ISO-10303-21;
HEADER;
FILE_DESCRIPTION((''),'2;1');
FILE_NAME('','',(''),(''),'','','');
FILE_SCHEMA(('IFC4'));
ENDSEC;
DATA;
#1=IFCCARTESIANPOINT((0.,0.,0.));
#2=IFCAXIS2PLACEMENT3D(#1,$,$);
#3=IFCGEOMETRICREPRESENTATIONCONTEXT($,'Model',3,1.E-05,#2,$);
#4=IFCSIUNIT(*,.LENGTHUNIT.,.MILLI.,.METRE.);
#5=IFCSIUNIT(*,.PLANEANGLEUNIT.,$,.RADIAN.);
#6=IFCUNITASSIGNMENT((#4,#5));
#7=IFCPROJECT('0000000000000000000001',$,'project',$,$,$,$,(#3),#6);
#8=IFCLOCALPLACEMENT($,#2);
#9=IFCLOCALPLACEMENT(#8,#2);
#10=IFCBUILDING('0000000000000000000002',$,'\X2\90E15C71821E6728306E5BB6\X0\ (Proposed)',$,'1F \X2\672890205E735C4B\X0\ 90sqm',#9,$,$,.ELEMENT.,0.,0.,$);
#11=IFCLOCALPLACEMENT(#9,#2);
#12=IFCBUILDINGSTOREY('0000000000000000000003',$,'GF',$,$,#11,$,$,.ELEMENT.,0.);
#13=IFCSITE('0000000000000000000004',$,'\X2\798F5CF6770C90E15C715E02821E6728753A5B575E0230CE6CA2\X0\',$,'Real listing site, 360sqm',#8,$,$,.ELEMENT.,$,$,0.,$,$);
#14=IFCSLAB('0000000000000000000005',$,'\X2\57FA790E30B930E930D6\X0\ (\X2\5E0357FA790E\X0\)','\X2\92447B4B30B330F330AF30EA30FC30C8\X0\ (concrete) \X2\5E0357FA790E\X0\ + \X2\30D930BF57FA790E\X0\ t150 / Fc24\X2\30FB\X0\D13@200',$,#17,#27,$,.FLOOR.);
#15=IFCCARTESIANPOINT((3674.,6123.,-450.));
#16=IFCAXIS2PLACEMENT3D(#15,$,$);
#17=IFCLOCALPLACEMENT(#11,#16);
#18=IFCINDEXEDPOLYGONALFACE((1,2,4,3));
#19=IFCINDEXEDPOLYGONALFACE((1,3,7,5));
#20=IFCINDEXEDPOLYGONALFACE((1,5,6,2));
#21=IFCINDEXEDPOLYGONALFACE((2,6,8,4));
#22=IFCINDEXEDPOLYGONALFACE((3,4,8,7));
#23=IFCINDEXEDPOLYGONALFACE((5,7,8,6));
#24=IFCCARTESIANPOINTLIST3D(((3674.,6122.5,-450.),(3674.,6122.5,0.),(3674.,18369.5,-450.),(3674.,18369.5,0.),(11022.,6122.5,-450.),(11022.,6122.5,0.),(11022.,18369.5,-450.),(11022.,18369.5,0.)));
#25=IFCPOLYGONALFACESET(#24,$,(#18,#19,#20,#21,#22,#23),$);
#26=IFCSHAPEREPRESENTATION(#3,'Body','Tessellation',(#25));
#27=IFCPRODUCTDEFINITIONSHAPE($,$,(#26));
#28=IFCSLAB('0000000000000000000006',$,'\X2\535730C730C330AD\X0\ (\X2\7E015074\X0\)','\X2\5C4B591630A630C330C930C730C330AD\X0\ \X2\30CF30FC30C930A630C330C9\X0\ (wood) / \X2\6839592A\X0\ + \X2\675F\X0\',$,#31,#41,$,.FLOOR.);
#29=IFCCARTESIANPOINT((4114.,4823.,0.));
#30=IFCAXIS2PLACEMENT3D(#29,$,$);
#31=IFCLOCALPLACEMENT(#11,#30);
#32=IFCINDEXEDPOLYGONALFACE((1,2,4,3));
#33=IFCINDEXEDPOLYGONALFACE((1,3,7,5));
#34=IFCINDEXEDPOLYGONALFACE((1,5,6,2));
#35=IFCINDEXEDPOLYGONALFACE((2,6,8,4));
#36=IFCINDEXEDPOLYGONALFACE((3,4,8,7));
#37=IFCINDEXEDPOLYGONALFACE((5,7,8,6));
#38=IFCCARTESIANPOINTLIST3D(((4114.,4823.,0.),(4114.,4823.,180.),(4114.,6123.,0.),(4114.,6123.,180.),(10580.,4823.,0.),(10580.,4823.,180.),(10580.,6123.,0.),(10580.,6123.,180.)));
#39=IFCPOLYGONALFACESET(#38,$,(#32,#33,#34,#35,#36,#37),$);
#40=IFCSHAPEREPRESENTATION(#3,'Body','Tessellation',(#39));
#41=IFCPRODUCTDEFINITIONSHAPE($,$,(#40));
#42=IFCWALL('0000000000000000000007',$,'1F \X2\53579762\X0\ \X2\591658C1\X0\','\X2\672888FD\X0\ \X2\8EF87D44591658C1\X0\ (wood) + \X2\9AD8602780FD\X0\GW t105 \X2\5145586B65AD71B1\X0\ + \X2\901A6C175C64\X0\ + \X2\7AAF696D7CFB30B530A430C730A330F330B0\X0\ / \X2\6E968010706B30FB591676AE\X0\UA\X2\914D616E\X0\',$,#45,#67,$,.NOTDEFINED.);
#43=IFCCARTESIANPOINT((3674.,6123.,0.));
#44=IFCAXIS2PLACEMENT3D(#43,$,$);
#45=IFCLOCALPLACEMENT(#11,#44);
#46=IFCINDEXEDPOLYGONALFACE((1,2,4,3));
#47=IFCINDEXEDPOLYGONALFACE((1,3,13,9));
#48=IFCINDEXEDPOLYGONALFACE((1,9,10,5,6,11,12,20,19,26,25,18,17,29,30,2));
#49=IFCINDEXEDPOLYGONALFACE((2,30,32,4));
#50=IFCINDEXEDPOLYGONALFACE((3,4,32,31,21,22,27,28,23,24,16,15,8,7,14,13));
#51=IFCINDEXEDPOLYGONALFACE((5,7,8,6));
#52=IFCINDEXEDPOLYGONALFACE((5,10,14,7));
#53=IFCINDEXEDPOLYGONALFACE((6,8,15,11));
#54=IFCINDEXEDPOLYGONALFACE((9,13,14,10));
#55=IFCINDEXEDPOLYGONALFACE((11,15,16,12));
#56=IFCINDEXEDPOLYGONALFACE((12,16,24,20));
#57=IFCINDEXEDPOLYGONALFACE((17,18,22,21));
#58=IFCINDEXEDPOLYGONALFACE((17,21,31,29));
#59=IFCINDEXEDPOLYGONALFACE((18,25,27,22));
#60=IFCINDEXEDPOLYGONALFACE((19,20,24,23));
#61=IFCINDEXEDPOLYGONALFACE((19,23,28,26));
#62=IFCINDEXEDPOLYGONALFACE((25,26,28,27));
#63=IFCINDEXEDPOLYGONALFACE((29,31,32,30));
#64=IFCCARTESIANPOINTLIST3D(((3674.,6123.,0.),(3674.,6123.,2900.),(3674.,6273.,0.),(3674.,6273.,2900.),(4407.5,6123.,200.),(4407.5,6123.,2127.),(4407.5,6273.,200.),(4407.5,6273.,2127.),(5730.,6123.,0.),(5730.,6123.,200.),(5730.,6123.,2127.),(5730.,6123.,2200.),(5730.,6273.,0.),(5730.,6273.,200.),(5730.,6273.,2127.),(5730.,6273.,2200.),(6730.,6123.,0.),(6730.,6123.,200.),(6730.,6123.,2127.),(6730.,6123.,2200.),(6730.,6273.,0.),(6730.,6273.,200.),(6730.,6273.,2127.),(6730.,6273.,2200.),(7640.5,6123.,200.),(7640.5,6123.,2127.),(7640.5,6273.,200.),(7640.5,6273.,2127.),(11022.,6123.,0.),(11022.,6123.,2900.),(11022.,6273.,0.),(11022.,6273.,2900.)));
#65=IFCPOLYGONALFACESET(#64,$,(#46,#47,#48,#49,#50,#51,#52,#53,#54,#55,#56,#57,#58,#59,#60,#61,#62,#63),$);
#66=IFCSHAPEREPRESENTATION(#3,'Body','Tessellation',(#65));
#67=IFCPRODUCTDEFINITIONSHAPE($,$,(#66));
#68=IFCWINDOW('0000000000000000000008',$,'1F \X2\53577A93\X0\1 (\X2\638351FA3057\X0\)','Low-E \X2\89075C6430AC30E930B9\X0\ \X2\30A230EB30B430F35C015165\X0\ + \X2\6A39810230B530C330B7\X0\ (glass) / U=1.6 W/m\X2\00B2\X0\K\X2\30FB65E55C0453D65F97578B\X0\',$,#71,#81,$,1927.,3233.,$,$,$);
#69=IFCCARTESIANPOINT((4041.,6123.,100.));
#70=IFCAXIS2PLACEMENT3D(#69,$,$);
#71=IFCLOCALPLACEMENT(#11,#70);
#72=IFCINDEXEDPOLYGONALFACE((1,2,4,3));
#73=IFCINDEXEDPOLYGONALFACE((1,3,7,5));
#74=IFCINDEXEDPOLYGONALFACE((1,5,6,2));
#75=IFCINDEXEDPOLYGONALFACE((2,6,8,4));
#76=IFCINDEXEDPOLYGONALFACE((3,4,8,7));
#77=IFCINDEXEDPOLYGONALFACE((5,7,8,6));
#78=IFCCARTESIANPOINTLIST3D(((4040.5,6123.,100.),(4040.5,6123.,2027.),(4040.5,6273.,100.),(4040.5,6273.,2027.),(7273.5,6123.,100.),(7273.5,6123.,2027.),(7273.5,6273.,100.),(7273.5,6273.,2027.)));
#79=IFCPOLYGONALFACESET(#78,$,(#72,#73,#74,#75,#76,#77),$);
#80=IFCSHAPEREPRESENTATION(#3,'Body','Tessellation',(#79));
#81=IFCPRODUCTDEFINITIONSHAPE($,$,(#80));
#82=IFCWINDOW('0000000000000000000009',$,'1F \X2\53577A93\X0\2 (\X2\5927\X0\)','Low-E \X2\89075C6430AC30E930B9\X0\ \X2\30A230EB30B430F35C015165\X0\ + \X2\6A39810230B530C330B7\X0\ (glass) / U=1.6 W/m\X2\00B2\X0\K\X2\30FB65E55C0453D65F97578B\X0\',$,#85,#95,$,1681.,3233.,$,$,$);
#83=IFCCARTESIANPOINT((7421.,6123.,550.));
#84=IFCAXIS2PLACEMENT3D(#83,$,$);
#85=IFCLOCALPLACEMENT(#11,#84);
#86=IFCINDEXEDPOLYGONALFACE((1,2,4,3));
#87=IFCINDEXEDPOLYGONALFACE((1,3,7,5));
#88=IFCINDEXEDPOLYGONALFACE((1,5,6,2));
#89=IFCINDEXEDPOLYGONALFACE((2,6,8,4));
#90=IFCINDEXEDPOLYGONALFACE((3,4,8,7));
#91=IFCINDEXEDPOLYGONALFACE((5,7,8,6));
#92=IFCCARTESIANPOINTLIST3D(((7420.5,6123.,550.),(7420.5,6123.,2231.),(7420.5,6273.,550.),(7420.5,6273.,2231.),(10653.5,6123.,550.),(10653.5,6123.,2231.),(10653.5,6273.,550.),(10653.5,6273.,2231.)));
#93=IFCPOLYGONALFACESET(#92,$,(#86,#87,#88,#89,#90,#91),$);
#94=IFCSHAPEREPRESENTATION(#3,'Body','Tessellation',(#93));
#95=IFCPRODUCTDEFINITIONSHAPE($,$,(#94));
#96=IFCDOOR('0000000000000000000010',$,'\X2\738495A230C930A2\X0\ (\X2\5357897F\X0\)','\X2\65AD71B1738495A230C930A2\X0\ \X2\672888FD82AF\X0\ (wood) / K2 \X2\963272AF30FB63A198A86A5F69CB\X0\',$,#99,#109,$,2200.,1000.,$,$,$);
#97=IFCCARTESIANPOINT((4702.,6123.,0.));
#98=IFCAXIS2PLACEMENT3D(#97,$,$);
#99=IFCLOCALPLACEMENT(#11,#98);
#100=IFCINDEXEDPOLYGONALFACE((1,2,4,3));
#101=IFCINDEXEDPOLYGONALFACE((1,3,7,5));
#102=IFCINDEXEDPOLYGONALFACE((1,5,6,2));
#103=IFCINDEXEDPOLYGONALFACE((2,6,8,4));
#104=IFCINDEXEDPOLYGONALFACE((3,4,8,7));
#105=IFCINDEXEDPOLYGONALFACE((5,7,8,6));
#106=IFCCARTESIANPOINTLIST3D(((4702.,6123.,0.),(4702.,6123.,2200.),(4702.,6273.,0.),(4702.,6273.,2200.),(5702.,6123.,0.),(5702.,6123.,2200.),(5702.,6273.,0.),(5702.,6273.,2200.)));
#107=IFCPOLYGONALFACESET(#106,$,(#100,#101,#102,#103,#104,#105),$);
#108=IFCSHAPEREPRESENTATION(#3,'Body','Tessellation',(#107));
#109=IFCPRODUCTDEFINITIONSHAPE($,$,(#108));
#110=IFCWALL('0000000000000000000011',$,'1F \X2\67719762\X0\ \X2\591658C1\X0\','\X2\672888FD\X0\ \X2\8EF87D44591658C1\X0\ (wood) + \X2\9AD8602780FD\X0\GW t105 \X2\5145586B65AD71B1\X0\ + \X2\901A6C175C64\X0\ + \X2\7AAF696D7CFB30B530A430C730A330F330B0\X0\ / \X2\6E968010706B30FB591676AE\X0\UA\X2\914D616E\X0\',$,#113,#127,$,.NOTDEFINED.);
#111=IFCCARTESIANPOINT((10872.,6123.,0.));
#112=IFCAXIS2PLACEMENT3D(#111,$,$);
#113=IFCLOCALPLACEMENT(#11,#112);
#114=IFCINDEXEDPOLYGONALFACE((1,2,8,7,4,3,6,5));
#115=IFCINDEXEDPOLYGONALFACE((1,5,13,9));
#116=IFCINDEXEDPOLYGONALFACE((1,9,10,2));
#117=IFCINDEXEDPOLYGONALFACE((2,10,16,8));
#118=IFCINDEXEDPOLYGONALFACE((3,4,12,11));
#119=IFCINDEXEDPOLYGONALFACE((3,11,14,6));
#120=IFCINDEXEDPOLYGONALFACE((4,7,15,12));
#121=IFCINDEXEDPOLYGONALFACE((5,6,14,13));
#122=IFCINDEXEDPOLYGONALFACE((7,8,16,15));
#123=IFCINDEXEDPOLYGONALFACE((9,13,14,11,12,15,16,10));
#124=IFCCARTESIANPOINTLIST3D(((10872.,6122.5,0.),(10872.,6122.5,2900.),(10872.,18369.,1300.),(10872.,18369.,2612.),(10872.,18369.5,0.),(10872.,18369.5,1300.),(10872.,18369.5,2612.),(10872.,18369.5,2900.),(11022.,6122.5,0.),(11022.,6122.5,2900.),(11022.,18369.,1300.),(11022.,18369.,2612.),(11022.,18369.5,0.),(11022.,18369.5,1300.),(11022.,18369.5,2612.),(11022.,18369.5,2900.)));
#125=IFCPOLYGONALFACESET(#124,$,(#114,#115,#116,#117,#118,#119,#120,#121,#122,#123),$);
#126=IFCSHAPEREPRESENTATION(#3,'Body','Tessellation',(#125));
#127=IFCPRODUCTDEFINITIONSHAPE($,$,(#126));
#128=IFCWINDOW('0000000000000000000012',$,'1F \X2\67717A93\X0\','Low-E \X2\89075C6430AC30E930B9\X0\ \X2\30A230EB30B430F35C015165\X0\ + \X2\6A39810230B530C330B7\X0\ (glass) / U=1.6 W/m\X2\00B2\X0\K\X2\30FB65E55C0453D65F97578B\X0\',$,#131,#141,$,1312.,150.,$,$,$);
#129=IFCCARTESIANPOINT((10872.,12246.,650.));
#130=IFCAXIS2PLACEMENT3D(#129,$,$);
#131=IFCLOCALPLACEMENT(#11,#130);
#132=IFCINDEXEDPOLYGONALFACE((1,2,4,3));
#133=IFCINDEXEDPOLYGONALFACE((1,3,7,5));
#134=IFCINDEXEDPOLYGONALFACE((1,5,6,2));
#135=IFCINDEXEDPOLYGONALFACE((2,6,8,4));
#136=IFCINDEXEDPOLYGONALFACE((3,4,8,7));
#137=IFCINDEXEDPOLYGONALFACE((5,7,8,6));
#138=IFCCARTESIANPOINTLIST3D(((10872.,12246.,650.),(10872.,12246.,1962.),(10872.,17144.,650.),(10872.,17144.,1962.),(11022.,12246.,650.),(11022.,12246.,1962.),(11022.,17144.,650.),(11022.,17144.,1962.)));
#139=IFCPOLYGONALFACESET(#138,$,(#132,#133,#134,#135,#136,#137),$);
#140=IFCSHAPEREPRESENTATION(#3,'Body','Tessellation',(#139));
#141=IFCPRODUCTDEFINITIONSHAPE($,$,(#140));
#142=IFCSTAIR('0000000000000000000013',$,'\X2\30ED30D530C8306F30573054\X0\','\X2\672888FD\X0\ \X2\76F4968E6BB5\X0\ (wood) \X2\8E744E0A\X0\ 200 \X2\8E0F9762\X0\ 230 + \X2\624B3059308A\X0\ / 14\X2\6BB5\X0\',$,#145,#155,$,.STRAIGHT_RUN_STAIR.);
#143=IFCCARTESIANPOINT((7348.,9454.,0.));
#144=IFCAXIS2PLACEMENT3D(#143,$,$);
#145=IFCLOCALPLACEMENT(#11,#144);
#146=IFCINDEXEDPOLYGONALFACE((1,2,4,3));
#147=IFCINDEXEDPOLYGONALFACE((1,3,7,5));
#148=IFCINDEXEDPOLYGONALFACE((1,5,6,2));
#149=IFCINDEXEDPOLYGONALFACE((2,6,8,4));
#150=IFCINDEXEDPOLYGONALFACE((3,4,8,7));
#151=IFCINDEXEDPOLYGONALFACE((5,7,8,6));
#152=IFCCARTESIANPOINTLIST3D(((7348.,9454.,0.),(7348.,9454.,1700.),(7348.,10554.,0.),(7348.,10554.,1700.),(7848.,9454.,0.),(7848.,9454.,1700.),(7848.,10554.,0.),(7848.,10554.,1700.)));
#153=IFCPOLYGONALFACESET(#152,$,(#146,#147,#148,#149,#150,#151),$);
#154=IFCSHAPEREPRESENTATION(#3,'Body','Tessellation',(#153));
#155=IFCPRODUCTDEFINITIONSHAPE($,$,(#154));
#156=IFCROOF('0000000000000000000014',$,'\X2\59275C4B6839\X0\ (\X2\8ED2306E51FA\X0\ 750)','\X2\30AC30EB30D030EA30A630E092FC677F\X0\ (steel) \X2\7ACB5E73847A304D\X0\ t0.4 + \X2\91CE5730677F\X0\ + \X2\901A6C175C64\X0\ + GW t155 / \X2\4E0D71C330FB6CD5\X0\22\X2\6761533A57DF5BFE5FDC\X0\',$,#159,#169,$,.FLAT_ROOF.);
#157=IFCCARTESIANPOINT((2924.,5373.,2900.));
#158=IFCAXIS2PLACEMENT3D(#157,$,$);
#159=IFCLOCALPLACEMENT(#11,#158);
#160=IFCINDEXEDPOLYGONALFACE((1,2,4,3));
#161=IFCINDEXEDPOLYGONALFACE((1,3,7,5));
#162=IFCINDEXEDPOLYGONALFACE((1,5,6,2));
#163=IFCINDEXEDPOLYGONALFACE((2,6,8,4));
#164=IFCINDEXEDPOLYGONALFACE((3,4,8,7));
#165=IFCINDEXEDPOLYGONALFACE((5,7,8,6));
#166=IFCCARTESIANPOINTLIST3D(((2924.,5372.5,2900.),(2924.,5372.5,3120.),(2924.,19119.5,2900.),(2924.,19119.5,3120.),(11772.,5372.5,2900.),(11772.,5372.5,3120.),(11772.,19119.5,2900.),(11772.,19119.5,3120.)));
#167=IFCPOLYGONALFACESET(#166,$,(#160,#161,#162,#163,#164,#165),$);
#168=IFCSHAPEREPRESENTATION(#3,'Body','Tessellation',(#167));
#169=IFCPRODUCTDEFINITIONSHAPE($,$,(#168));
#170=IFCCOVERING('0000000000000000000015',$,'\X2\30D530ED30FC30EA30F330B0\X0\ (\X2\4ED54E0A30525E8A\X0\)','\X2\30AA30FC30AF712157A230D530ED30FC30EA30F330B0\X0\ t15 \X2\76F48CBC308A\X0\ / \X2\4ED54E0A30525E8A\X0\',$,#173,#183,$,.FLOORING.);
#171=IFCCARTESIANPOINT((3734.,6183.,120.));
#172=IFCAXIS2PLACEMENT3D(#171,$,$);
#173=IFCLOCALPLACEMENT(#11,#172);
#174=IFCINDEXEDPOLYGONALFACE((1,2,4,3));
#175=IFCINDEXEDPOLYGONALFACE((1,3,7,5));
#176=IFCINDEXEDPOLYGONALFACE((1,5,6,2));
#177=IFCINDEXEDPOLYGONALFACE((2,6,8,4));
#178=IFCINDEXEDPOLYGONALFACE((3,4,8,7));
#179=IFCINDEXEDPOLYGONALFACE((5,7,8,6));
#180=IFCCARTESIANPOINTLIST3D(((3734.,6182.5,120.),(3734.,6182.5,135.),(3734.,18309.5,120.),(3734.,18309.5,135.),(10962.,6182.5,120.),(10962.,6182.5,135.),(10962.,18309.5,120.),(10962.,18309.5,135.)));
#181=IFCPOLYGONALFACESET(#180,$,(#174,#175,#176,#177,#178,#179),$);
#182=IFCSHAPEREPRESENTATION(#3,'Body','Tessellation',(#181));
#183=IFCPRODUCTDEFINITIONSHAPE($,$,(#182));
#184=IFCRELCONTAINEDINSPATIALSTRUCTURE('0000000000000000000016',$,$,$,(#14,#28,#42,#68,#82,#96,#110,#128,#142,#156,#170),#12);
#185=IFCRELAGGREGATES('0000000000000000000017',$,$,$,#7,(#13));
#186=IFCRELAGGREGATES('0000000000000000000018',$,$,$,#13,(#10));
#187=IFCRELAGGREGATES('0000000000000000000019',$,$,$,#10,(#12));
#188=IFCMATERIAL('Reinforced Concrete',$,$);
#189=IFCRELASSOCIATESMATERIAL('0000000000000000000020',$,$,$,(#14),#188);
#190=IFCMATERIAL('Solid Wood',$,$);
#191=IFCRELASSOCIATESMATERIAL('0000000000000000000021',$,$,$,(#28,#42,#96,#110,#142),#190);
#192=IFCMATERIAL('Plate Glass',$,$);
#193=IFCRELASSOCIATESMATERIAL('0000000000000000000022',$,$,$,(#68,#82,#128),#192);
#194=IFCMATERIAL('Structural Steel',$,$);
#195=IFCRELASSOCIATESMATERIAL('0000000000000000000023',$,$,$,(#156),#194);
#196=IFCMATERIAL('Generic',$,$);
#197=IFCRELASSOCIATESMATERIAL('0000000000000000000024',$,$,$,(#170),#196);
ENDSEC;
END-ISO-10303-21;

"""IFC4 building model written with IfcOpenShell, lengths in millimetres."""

from ifc_helpers import new_model, si_unit, frame, frame_2d, origin, place, context, project, spatial, rectangle, extrude, material, element, fill, save


model = new_model("IFC4")

# Units and contexts
model_context = context("Model", 3, precision=1e-05, world=origin())
ifc_project = project(units=[si_unit("LENGTHUNIT", "METRE", prefix="MILLI"), si_unit("PLANEANGLEUNIT", "RADIAN")], contexts=[model_context])

# Site, building, storey
site_placement = place(None, origin())
site = spatial("IfcSite", under=ifc_project, at=site_placement, Name="福島県郡山市舞木町字市ノ沢", ObjectType="Real listing site, 360sqm", CompositionType="ELEMENT", RefElevation=0.0)
building_placement = place(site_placement, origin())
building = spatial("IfcBuilding", under=site, at=building_placement, Name="郡山舞木の家 (Proposed)", ObjectType="1F 木造平屋 90sqm", CompositionType="ELEMENT", ElevationOfRefHeight=0.0, ElevationOfTerrain=0.0)
storey_placement = place(building_placement, origin())
storey = spatial("IfcBuildingStorey", under=building, at=storey_placement, Name="GF", CompositionType="ELEMENT", Elevation=0.0)

# Slabs
ifc_material_1 = material(Name="Reinforced Concrete")
slab_1_placement = place(storey_placement, frame((3674.0, 6123.0, -450.0)))
element("IfcSlab", 1, at=slab_1_placement, inside=storey, material=ifc_material_1, Name="基礎スラブ (布基礎)", Description="鉄筋コンクリート (concrete) 布基礎 + ベタ基礎 t150 / Fc24・D13@200", PredefinedType="FLOOR", context=model_context, shape_type="SweptSolid", body=[
    extrude(rectangle(XDim=7348.0, YDim=12247.0, at=frame_2d((3674.0, 6123.0))), frame((3674.0, 6123.0, -450.0)), (0.0, 0.0, 1.0), 450.0),
])
ifc_material_2 = material(Name="Solid Wood")
slab_2_placement = place(storey_placement, frame((4114.0, 4823.0, 0.0)))
element("IfcSlab", 2, at=slab_2_placement, inside=storey, material=ifc_material_2, Name="南デッキ (縁側)", Description="屋外ウッドデッキ ハードウッド (wood) / 根太 + 束", PredefinedType="FLOOR", context=model_context, shape_type="SweptSolid", body=[
    extrude(rectangle(XDim=6466.0, YDim=1300.0, at=frame_2d((3233.0, 650.0))), frame((4114.0, 4823.0, 0.0)), (0.0, 0.0, 1.0), 180.0),
])

# Wall, openings, windows, door
wall_1_placement = place(storey_placement, frame((3674.0, 6123.0, 0.0)))
wall_1 = element("IfcWall", 3, at=wall_1_placement, inside=storey, material=ifc_material_2, Name="1F 南面 外壁", Description="木製 軸組外壁 (wood) + 高性能GW t105 充填断熱 + 通気層 + 窯業系サイディング / 準耐火・外皮UA配慮", PredefinedType="NOTDEFINED", context=model_context, shape_type="SweptSolid", body=[
    extrude(rectangle(XDim=7348.0, YDim=150.0, at=frame_2d((3674.0, 75.0))), frame((3674.0, 6123.0, 0.0)), (0.0, 0.0, 1.0), 2900.0),
])
opening_1_placement = place(storey_placement, frame((4041.0, 6123.0, 100.0)))
opening_1 = element("IfcOpeningElement", 4, at=opening_1_placement, cuts=wall_1, PredefinedType="NOTDEFINED", context=model_context, shape_type="SweptSolid", body=[
    extrude(rectangle(XDim=3233.0, YDim=150.0, at=frame_2d((1616.0, 75.0))), frame((4041.0, 6123.0, 100.0)), (0.0, 0.0, 1.0), 1927.0),
])
opening_2_placement = place(storey_placement, frame((7421.0, 6123.0, 550.0)))
opening_2 = element("IfcOpeningElement", 5, at=opening_2_placement, cuts=wall_1, PredefinedType="NOTDEFINED", context=model_context, shape_type="SweptSolid", body=[
    extrude(rectangle(XDim=3233.0, YDim=150.0, at=frame_2d((1616.0, 75.0))), frame((7421.0, 6123.0, 550.0)), (0.0, 0.0, 1.0), 1681.0),
])
opening_3_placement = place(storey_placement, frame((4702.0, 6123.0, 0.0)))
opening_3 = element("IfcOpeningElement", 6, at=opening_3_placement, cuts=wall_1, PredefinedType="NOTDEFINED", context=model_context, shape_type="SweptSolid", body=[
    extrude(rectangle(XDim=1000.0, YDim=150.0, at=frame_2d((500.0, 75.0))), frame((4702.0, 6123.0, 0.0)), (0.0, 0.0, 1.0), 2200.0),
])
ifc_material_3 = material(Name="Plate Glass")
window_1_placement = place(storey_placement, frame((4041.0, 6123.0, 100.0)))
window_1 = element("IfcWindow", 7, at=window_1_placement, inside=storey, material=ifc_material_3, Name="1F 南窓1 (掃出し)", Description="Low-E 複層ガラス アルゴン封入 + 樹脂サッシ (glass) / U=1.6 W/m²K・日射取得型", OverallHeight=1927.0, OverallWidth=3233.0, context=model_context, shape_type="SweptSolid", body=[
    extrude(rectangle(XDim=3233.0, YDim=150.0, at=frame_2d((1616.0, 75.0))), frame((4041.0, 6123.0, 100.0)), (0.0, 0.0, 1.0), 1927.0),
])
fill(opening_1, window_1)
window_2_placement = place(storey_placement, frame((7421.0, 6123.0, 550.0)))
window_2 = element("IfcWindow", 8, at=window_2_placement, inside=storey, material=ifc_material_3, Name="1F 南窓2 (大)", Description="Low-E 複層ガラス アルゴン封入 + 樹脂サッシ (glass) / U=1.6 W/m²K・日射取得型", OverallHeight=1681.0, OverallWidth=3233.0, context=model_context, shape_type="SweptSolid", body=[
    extrude(rectangle(XDim=3233.0, YDim=150.0, at=frame_2d((1616.0, 75.0))), frame((7421.0, 6123.0, 550.0)), (0.0, 0.0, 1.0), 1681.0),
])
fill(opening_2, window_2)
door_placement = place(storey_placement, frame((4702.0, 6123.0, 0.0)))
door = element("IfcDoor", 9, at=door_placement, inside=storey, material=ifc_material_2, Name="玄関ドア (南西)", Description="断熱玄関ドア 木製芯 (wood) / K2 防犯・採風機構", OverallHeight=2200.0, OverallWidth=1000.0, context=model_context, shape_type="SweptSolid", body=[
    extrude(rectangle(XDim=1000.0, YDim=150.0, at=frame_2d((500.0, 75.0))), frame((4702.0, 6123.0, 0.0)), (0.0, 0.0, 1.0), 2200.0),
])
fill(opening_3, door)

# Wall, opening, window
wall_2_placement = place(storey_placement, frame((10872.0, 6123.0, 0.0)))
wall_2 = element("IfcWall", 10, at=wall_2_placement, inside=storey, material=ifc_material_2, Name="1F 東面 外壁", Description="木製 軸組外壁 (wood) + 高性能GW t105 充填断熱 + 通気層 + 窯業系サイディング / 準耐火・外皮UA配慮", PredefinedType="NOTDEFINED", context=model_context, shape_type="SweptSolid", body=[
    extrude(rectangle(XDim=150.0, YDim=12247.0, at=frame_2d((75.0, 6123.0))), frame((10872.0, 6123.0, 0.0)), (0.0, 0.0, 1.0), 2900.0),
])
opening_4_placement = place(storey_placement, frame((10872.0, 12246.0, 650.0)))
opening_4 = element("IfcOpeningElement", 11, at=opening_4_placement, cuts=wall_2, PredefinedType="NOTDEFINED", context=model_context, shape_type="SweptSolid", body=[
    extrude(rectangle(XDim=150.0, YDim=4898.0, at=frame_2d((75.0, 2449.0))), frame((10872.0, 12246.0, 650.0)), (0.0, 0.0, 1.0), 1312.0),
])
window_3_placement = place(storey_placement, frame((10872.0, 12246.0, 650.0)))
window_3 = element("IfcWindow", 12, at=window_3_placement, inside=storey, material=ifc_material_3, Name="1F 東窓", Description="Low-E 複層ガラス アルゴン封入 + 樹脂サッシ (glass) / U=1.6 W/m²K・日射取得型", OverallHeight=1312.0, OverallWidth=150.0, context=model_context, shape_type="SweptSolid", body=[
    extrude(rectangle(XDim=150.0, YDim=4898.0, at=frame_2d((75.0, 2449.0))), frame((10872.0, 12246.0, 650.0)), (0.0, 0.0, 1.0), 1312.0),
])
fill(opening_4, window_3)

# Stair
stair_placement = place(storey_placement, frame((7348.0, 9454.0, 0.0)))
element("IfcStair", 13, at=stair_placement, inside=storey, material=ifc_material_2, Name="ロフトはしご", Description="木製 直階段 (wood) 蹴上 200 踏面 230 + 手すり / 14段", PredefinedType="STRAIGHT_RUN_STAIR", context=model_context, shape_type="SweptSolid", body=[
    extrude(rectangle(XDim=500.0, YDim=1100.0, at=frame_2d((250.0, 550.0))), frame((7348.0, 9454.0, 0.0)), (0.0, 0.0, 1.0), 1700.0),
])

# Roof
ifc_material_4 = material(Name="Structural Steel")
roof_placement = place(storey_placement, frame((2924.0, 5373.0, 2900.0)))
element("IfcRoof", 14, at=roof_placement, inside=storey, material=ifc_material_4, Name="大屋根 (軒の出 750)", Description="ガルバリウム鋼板 (steel) 立平葺き t0.4 + 野地板 + 通気層 + GW t155 / 不燃・法22条区域対応", PredefinedType="FLAT_ROOF", context=model_context, shape_type="SweptSolid", body=[
    extrude(rectangle(XDim=8848.0, YDim=13747.0, at=frame_2d((4424.0, 6873.0))), frame((2924.0, 5373.0, 2900.0)), (0.0, 0.0, 1.0), 220.0),
])

# Covering
ifc_material_5 = material(Name="Generic")
covering_placement = place(storey_placement, frame((3734.0, 6183.0, 120.0)))
element("IfcCovering", 15, at=covering_placement, inside=storey, material=ifc_material_5, Name="フローリング (仕上げ床)", Description="オーク無垢フローリング t15 直貼り / 仕上げ床", PredefinedType="FLOORING", context=model_context, shape_type="SweptSolid", body=[
    extrude(rectangle(XDim=7228.0, YDim=12127.0, at=frame_2d((3614.0, 6063.0))), frame((3734.0, 6183.0, 120.0)), (0.0, 0.0, 1.0), 15.0),
])

save(model, "model.ifc")
